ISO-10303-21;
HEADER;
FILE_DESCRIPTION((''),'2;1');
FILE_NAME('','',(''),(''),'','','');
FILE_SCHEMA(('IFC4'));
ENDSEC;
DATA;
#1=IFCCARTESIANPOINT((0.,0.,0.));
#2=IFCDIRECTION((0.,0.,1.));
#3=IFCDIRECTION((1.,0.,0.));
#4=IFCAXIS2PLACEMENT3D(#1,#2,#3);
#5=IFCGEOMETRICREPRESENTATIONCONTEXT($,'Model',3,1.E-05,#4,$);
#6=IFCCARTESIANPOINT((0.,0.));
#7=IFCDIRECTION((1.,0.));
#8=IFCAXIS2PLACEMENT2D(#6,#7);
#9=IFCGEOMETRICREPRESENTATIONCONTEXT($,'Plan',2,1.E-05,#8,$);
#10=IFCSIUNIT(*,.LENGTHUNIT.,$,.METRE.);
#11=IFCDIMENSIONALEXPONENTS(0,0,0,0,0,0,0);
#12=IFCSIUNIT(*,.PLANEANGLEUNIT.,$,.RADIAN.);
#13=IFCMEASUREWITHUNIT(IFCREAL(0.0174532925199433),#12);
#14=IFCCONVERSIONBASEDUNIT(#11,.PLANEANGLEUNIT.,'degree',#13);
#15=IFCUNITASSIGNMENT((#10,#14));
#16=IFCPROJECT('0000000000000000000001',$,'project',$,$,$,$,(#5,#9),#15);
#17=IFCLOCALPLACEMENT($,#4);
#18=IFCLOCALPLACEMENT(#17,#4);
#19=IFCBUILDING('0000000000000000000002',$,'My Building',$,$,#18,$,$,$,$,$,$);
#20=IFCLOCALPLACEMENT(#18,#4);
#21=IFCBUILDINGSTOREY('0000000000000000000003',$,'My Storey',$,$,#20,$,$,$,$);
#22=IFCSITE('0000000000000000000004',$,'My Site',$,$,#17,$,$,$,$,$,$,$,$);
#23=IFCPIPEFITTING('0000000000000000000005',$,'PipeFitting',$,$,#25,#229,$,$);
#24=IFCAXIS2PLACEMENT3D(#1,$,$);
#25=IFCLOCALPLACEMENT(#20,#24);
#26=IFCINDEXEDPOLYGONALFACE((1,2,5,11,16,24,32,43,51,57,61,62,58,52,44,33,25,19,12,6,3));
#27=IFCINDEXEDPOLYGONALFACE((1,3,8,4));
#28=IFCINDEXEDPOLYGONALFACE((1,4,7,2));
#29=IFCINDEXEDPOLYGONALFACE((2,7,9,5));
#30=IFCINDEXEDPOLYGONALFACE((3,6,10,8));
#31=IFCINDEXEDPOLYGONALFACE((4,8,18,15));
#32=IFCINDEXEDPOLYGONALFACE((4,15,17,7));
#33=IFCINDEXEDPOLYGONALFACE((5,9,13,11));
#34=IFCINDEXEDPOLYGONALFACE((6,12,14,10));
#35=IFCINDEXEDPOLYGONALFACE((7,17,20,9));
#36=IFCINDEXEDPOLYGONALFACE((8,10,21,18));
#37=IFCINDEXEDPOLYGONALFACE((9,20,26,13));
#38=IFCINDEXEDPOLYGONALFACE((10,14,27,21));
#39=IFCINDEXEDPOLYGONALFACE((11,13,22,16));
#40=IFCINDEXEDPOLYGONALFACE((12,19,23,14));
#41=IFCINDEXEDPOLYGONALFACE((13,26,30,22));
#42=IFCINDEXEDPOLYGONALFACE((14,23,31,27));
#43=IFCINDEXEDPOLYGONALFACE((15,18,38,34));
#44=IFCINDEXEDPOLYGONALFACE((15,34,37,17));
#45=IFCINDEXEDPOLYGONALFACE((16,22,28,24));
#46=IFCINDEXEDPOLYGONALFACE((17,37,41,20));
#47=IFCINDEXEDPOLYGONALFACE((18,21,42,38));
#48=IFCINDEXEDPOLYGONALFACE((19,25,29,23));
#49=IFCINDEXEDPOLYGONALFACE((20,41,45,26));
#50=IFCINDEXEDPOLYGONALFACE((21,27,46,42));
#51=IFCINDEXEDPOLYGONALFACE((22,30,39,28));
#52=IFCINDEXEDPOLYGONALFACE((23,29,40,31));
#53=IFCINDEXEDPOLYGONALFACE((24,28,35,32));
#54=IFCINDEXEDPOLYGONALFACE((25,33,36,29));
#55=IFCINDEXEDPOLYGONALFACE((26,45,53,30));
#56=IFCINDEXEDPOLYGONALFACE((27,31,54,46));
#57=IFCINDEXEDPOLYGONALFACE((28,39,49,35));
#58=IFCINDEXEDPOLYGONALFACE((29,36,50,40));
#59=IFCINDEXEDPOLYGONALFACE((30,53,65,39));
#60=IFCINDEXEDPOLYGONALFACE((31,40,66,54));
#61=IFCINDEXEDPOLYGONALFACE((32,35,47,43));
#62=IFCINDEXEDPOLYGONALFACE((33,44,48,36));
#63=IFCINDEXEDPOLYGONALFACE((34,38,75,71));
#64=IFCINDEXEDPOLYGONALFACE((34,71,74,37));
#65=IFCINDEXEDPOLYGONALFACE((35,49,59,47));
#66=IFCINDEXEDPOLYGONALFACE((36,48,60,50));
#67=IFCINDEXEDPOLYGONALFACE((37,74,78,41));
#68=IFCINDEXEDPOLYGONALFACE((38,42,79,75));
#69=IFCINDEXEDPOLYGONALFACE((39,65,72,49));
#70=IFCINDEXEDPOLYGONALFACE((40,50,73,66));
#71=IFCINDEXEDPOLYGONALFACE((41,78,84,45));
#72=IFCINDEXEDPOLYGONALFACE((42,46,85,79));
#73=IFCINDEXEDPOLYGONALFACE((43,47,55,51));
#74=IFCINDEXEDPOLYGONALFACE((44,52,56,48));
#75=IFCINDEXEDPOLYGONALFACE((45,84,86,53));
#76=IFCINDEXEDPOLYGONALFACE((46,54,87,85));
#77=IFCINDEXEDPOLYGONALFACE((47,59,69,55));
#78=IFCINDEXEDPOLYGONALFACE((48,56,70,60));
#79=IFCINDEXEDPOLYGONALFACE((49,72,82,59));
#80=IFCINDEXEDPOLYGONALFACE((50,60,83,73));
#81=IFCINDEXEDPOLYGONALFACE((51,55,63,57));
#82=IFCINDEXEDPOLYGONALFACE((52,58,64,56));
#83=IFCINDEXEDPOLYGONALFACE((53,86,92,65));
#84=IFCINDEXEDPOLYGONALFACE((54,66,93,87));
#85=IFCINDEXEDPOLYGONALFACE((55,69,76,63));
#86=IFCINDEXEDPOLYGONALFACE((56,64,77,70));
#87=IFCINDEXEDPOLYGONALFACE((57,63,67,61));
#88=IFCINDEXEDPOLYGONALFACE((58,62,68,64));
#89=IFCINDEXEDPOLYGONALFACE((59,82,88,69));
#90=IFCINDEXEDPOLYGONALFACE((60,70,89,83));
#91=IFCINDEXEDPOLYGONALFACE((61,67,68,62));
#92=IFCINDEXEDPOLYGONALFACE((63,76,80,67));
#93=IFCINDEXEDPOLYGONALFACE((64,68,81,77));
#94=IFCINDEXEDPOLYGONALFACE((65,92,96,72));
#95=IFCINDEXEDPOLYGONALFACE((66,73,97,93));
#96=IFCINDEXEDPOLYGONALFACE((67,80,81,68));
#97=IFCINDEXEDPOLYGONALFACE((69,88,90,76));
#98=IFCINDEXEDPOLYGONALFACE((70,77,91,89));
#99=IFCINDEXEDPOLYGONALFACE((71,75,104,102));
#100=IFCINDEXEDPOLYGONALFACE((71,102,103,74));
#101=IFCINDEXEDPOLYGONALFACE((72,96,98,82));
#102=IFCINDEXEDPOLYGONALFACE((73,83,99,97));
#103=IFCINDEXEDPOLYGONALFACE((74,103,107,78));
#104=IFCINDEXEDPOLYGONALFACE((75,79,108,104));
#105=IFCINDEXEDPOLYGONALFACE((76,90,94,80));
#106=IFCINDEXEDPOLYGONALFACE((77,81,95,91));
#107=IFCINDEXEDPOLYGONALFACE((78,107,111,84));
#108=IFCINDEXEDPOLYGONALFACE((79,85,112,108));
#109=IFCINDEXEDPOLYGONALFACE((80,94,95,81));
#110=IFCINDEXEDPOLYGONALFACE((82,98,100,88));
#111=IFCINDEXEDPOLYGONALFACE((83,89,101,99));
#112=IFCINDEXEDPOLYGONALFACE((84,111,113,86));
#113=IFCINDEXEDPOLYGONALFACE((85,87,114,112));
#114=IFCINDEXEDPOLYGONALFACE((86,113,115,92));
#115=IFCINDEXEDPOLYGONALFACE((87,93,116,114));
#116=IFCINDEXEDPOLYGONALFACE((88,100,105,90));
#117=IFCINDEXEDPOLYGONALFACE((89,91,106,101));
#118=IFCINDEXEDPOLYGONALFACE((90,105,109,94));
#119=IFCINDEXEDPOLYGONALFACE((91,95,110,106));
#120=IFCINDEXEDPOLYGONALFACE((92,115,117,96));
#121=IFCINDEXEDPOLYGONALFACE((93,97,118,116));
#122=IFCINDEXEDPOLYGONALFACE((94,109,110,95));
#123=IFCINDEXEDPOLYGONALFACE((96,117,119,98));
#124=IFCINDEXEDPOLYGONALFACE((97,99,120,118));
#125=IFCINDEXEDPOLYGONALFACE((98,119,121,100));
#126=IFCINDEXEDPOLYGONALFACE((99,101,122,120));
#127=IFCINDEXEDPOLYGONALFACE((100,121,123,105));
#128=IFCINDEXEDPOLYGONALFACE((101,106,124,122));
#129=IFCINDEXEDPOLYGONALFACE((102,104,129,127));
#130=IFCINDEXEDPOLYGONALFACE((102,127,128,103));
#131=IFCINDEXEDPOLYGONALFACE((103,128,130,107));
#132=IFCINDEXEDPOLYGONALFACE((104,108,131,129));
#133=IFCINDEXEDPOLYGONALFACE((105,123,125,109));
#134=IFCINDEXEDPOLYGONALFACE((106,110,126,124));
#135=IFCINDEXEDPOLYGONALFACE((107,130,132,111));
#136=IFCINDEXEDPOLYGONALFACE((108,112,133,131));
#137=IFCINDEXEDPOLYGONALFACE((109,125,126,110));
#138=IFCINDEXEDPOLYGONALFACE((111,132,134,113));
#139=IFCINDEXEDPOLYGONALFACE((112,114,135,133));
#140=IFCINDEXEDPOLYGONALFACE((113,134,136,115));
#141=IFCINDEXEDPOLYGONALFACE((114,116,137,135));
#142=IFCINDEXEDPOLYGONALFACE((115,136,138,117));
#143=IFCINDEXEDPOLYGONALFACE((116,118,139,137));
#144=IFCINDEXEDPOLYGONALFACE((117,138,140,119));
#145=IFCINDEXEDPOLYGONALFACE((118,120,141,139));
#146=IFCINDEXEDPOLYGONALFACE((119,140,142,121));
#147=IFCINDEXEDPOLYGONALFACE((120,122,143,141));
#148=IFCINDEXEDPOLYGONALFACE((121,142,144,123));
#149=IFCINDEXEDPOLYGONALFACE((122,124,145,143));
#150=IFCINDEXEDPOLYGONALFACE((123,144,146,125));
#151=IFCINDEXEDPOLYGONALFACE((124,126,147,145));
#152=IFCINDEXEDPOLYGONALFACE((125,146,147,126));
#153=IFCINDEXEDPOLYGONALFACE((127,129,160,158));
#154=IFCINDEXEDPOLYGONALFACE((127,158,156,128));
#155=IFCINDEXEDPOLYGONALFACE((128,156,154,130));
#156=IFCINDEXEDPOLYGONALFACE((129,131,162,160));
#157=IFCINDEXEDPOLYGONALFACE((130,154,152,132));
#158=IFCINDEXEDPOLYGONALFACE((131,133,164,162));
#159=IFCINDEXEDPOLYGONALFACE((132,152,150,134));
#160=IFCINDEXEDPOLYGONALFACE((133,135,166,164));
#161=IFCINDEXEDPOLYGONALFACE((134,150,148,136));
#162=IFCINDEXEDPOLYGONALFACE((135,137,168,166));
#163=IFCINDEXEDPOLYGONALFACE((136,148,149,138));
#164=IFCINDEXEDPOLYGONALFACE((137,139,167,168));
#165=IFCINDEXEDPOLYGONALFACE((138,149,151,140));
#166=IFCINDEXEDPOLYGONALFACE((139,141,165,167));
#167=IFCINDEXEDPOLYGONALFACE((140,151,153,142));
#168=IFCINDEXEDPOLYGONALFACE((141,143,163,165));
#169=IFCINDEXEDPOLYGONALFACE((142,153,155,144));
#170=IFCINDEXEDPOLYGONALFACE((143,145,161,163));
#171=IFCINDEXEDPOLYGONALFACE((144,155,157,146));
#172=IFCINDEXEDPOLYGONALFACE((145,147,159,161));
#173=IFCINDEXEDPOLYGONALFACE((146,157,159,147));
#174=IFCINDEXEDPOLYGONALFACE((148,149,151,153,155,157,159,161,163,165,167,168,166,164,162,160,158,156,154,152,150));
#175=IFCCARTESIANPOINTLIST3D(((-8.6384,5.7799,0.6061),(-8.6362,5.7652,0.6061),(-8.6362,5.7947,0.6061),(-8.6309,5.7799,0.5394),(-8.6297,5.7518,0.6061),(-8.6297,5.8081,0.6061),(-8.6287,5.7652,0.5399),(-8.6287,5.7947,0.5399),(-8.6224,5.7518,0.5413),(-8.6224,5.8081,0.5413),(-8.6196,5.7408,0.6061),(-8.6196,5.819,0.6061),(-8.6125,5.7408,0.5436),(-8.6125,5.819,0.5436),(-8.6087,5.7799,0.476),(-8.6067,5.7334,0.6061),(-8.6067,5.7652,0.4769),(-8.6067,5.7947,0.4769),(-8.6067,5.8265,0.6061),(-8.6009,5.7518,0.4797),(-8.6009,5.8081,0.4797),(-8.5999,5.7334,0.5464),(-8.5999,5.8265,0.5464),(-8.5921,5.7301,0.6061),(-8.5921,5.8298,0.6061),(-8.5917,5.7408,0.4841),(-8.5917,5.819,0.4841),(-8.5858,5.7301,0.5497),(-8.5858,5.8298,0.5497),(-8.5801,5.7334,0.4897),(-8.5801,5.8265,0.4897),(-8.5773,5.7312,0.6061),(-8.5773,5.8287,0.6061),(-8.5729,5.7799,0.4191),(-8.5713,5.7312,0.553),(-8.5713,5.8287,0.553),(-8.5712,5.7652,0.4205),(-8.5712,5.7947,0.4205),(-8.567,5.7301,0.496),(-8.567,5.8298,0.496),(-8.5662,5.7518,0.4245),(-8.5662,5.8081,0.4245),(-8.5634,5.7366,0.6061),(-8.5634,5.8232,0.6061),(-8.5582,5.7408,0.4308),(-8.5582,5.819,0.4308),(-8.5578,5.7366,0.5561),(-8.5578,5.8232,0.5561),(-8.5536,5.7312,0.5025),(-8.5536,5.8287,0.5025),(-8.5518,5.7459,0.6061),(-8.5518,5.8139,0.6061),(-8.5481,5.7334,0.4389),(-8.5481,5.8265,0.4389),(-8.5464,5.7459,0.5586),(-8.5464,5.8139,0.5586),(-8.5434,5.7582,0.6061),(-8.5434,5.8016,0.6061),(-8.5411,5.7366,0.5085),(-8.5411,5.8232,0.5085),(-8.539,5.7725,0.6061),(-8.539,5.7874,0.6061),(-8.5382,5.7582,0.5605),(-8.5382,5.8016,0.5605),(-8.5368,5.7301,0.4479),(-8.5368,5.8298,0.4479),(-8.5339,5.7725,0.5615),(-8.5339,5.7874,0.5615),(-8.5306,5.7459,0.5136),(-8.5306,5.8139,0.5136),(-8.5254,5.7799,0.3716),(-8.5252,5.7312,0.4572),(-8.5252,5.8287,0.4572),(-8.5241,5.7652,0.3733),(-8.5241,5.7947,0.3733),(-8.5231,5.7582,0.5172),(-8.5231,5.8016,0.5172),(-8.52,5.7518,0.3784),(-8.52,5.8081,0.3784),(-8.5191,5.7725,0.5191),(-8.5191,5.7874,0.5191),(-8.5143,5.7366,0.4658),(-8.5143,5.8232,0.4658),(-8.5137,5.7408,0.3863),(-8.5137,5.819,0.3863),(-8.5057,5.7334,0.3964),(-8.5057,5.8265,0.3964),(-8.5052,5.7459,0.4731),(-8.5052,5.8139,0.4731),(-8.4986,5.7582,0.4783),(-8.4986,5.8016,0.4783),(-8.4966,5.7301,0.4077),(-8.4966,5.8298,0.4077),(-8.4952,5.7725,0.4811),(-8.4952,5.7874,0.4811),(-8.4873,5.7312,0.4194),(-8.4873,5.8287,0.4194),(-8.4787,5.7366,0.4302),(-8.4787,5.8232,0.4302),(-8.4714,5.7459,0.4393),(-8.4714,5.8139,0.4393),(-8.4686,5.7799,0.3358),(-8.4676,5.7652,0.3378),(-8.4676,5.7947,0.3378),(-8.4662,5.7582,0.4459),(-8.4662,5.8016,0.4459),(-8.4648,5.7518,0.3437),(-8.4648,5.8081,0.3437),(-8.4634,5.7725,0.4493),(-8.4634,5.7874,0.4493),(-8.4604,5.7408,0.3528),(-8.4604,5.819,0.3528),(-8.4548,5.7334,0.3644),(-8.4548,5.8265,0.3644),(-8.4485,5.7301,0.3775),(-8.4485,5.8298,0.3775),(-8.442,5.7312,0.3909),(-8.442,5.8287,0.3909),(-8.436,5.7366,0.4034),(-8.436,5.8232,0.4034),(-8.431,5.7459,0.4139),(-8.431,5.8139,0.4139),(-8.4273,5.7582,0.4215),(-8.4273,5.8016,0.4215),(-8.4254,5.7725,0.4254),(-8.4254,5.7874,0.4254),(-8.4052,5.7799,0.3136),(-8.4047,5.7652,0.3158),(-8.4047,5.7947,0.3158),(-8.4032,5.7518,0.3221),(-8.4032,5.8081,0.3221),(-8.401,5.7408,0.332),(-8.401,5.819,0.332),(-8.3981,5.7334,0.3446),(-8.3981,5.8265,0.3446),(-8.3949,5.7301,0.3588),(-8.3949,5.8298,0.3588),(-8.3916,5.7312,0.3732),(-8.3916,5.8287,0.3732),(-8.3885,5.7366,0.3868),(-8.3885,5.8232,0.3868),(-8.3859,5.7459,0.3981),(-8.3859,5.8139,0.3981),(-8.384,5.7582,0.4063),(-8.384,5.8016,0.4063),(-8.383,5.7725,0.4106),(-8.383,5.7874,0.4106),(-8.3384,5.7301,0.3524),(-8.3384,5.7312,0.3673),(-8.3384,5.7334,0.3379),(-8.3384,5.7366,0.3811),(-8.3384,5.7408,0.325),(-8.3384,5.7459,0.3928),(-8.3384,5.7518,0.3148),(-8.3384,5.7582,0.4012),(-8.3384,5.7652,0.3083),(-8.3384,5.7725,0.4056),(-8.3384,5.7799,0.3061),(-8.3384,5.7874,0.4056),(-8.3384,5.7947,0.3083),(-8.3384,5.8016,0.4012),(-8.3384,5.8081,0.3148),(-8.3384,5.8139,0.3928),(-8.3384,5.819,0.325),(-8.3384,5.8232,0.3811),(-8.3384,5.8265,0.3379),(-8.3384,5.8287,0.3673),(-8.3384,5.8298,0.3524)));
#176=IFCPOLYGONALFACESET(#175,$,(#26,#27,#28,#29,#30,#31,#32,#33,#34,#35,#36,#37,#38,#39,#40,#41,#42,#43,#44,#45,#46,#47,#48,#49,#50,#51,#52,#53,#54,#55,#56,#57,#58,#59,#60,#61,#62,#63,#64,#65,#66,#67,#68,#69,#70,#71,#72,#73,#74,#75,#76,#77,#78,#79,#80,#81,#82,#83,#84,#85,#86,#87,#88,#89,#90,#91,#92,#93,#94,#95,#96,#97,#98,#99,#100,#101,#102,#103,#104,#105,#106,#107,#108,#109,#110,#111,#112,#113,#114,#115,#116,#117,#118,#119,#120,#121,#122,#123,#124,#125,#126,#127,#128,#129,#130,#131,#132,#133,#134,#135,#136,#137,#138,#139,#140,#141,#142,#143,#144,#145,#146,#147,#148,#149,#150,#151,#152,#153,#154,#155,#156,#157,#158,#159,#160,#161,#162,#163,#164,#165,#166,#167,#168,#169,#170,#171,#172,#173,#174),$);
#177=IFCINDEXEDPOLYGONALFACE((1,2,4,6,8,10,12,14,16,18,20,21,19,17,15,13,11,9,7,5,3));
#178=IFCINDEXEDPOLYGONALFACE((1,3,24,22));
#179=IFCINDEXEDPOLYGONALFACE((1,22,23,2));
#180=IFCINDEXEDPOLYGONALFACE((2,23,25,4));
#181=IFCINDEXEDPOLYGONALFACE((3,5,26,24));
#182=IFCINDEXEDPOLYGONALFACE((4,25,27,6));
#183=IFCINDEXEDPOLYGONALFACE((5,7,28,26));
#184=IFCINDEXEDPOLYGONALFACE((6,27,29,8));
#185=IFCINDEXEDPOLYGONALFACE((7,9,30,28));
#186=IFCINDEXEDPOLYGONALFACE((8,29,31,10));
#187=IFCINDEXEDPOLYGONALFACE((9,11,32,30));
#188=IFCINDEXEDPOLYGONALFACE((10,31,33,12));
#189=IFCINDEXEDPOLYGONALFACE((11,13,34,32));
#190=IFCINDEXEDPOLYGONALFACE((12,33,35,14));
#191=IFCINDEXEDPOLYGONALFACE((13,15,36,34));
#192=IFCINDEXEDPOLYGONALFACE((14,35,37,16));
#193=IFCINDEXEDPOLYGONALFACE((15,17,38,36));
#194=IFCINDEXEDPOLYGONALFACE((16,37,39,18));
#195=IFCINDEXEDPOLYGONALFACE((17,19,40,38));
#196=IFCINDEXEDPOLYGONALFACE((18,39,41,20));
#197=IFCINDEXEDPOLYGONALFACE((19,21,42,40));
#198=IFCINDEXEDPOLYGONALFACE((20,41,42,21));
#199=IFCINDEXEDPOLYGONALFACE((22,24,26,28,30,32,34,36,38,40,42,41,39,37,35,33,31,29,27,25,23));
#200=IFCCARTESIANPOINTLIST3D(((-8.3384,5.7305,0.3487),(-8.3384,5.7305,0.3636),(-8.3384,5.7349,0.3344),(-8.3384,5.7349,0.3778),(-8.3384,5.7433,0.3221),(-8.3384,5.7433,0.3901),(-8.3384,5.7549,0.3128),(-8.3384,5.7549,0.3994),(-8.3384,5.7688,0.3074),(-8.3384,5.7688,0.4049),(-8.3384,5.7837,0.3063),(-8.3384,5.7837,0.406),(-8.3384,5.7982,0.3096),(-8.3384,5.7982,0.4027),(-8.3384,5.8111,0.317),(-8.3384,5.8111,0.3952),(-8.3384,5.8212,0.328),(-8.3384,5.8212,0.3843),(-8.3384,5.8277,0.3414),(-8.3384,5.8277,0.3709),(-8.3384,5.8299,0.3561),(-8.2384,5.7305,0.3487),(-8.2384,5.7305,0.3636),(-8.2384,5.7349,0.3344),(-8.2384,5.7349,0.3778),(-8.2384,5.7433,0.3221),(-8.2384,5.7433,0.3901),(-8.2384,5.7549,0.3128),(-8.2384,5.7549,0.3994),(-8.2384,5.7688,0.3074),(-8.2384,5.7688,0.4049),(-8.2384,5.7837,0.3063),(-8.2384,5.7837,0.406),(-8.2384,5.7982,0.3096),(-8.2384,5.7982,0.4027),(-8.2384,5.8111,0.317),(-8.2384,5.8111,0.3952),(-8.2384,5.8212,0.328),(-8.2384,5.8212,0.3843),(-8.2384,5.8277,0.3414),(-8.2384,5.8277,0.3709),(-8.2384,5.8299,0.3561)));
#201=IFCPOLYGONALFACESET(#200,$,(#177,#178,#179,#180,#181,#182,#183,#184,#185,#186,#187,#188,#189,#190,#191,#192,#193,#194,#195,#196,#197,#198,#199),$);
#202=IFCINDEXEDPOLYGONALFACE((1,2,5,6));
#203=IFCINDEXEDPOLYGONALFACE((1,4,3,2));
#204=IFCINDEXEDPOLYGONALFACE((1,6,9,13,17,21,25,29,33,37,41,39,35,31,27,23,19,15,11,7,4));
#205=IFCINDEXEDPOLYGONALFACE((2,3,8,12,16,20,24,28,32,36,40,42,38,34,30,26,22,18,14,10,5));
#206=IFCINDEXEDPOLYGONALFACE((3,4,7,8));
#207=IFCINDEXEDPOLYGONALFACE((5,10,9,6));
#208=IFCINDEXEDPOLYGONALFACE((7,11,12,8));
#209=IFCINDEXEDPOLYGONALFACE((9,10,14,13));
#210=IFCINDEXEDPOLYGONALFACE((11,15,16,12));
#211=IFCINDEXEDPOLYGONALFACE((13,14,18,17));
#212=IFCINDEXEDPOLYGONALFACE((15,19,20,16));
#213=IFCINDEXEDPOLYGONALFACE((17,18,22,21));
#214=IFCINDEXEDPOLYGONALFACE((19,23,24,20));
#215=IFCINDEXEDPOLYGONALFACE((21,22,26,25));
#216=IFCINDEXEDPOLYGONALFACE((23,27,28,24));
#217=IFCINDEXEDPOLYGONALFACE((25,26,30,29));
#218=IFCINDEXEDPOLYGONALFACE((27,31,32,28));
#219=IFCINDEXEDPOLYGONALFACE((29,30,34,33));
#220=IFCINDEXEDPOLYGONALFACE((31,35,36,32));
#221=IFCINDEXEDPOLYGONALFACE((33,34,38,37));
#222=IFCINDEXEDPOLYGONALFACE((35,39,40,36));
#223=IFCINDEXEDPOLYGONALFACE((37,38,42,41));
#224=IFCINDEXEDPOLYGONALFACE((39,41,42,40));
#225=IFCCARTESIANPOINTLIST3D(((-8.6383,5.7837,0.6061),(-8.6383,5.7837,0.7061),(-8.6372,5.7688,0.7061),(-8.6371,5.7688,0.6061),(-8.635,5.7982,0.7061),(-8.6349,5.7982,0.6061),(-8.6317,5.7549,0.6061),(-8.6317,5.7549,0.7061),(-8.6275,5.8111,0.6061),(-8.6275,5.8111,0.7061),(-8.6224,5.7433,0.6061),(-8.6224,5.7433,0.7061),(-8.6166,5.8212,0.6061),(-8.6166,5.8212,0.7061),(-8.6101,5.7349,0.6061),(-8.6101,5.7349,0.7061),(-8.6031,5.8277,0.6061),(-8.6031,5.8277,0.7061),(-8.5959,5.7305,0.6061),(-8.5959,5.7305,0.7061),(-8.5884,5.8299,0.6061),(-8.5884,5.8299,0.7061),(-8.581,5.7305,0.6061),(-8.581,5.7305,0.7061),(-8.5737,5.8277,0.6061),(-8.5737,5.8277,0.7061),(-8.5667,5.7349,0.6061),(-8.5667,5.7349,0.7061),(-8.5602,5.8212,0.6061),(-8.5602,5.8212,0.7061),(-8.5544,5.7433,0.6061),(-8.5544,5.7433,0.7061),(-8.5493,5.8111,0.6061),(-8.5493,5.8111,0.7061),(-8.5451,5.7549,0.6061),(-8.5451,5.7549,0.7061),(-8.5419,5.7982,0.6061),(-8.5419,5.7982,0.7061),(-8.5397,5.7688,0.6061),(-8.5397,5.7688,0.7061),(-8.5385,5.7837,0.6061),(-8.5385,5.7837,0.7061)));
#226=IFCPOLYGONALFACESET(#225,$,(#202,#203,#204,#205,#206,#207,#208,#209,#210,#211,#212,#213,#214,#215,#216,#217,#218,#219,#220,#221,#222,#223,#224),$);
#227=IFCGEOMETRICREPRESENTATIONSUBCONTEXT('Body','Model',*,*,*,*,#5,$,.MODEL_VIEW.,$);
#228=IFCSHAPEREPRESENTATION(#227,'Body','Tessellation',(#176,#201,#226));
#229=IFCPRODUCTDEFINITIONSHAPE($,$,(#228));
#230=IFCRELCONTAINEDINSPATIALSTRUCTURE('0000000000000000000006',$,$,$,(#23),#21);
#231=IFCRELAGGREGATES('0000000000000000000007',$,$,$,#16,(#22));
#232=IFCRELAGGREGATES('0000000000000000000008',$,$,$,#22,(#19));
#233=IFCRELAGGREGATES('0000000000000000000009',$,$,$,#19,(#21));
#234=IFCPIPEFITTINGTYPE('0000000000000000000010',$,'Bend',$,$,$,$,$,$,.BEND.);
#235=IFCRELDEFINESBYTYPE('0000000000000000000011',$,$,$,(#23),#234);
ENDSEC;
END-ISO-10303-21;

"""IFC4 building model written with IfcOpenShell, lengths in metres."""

from ifc_helpers import new_model, entity, si_unit, converted_unit, frame, origin_with_axes, origin_2d_with_axis, place, context, subcontext, project, spatial, circle, extrude, source, transform, mapped, type_object, type_shapes, element, save


model = new_model("IFC4")

# Units and contexts
model_context = context("Model", 3, precision=1e-05, world=origin_with_axes())
plan_context = context("Plan", 2, precision=1e-05, world=origin_2d_with_axis())
body_context = subcontext(model_context, "Body", "Model", "MODEL_VIEW")
ifc_project = project(units=[si_unit("LENGTHUNIT", "METRE"), converted_unit("PLANEANGLEUNIT", "degree", entity("IfcReal", 0.0174532925199433), si_unit("PLANEANGLEUNIT", "RADIAN"), dimensions=[0, 0, 0, 0, 0, 0, 0])], contexts=[model_context, plan_context])

# Site, building, storey
site_placement = place(None, origin_with_axes())
site = spatial("IfcSite", under=ifc_project, at=site_placement, Name="My Site")
building_placement = place(site_placement, origin_with_axes())
building = spatial("IfcBuilding", under=site, at=building_placement, Name="My Building")
storey_placement = place(building_placement, origin_with_axes())
storey = spatial("IfcBuildingStorey", under=building, at=storey_placement, Name="My Storey")

# Pipe fitting
pipe_fitting_type_1 = type_object("IfcPipeFittingType", Name="Bend", PredefinedType="BEND")
shared_shape_1 = source(origin_with_axes(), body_context, "Body", "SolidModel", [
    entity("IfcSweptDiskSolid", entity("IfcIndexedPolyCurve", entity("IfcCartesianPointList3D", [[0.0, 0.0, 0.1], [0.0, -0.0732, 0.2768], [0.0, -0.25, 0.35]]), [entity("IfcArcIndex", [1, 2, 3])]), 0.05),
    extrude(circle(Radius=0.05), origin_with_axes(), (0.0, 0.0, 1.0), 0.1),
    extrude(circle(Radius=0.05), frame((0.0, -0.25, 0.35), z_axis=(0.0, -1.0, 0.000038), x_axis=(1.0, 0.0, 0.0)), (0.0, 0.0, 1.0), 0.1),
])
type_shapes(pipe_fitting_type_1, [shared_shape_1])
for number, where, z_axis, x_axis, name in (
    (1, (-8.2384, 5.7799, 0.3561), (-1.0, 0.0, 0.0), (0.0, 1.0, 0.0), "PipeFitting"),
):
    element("IfcPipeFitting", number, at=place(storey_placement, frame(where, z_axis=z_axis, x_axis=x_axis)), inside=storey, type_object=pipe_fitting_type_1, Name=name, context=body_context, shape_type="MappedRepresentation", body=[
        mapped(shared_shape_1, transform((0.0, 0.0, 0.0), x_axis=(1.0, 0.0, 0.0), y_axis=(0.0, 1.0, 0.0), z_axis=(0.0, 0.0, 1.0), scale=1.0)),
    ])

save(model, "model.ifc")
